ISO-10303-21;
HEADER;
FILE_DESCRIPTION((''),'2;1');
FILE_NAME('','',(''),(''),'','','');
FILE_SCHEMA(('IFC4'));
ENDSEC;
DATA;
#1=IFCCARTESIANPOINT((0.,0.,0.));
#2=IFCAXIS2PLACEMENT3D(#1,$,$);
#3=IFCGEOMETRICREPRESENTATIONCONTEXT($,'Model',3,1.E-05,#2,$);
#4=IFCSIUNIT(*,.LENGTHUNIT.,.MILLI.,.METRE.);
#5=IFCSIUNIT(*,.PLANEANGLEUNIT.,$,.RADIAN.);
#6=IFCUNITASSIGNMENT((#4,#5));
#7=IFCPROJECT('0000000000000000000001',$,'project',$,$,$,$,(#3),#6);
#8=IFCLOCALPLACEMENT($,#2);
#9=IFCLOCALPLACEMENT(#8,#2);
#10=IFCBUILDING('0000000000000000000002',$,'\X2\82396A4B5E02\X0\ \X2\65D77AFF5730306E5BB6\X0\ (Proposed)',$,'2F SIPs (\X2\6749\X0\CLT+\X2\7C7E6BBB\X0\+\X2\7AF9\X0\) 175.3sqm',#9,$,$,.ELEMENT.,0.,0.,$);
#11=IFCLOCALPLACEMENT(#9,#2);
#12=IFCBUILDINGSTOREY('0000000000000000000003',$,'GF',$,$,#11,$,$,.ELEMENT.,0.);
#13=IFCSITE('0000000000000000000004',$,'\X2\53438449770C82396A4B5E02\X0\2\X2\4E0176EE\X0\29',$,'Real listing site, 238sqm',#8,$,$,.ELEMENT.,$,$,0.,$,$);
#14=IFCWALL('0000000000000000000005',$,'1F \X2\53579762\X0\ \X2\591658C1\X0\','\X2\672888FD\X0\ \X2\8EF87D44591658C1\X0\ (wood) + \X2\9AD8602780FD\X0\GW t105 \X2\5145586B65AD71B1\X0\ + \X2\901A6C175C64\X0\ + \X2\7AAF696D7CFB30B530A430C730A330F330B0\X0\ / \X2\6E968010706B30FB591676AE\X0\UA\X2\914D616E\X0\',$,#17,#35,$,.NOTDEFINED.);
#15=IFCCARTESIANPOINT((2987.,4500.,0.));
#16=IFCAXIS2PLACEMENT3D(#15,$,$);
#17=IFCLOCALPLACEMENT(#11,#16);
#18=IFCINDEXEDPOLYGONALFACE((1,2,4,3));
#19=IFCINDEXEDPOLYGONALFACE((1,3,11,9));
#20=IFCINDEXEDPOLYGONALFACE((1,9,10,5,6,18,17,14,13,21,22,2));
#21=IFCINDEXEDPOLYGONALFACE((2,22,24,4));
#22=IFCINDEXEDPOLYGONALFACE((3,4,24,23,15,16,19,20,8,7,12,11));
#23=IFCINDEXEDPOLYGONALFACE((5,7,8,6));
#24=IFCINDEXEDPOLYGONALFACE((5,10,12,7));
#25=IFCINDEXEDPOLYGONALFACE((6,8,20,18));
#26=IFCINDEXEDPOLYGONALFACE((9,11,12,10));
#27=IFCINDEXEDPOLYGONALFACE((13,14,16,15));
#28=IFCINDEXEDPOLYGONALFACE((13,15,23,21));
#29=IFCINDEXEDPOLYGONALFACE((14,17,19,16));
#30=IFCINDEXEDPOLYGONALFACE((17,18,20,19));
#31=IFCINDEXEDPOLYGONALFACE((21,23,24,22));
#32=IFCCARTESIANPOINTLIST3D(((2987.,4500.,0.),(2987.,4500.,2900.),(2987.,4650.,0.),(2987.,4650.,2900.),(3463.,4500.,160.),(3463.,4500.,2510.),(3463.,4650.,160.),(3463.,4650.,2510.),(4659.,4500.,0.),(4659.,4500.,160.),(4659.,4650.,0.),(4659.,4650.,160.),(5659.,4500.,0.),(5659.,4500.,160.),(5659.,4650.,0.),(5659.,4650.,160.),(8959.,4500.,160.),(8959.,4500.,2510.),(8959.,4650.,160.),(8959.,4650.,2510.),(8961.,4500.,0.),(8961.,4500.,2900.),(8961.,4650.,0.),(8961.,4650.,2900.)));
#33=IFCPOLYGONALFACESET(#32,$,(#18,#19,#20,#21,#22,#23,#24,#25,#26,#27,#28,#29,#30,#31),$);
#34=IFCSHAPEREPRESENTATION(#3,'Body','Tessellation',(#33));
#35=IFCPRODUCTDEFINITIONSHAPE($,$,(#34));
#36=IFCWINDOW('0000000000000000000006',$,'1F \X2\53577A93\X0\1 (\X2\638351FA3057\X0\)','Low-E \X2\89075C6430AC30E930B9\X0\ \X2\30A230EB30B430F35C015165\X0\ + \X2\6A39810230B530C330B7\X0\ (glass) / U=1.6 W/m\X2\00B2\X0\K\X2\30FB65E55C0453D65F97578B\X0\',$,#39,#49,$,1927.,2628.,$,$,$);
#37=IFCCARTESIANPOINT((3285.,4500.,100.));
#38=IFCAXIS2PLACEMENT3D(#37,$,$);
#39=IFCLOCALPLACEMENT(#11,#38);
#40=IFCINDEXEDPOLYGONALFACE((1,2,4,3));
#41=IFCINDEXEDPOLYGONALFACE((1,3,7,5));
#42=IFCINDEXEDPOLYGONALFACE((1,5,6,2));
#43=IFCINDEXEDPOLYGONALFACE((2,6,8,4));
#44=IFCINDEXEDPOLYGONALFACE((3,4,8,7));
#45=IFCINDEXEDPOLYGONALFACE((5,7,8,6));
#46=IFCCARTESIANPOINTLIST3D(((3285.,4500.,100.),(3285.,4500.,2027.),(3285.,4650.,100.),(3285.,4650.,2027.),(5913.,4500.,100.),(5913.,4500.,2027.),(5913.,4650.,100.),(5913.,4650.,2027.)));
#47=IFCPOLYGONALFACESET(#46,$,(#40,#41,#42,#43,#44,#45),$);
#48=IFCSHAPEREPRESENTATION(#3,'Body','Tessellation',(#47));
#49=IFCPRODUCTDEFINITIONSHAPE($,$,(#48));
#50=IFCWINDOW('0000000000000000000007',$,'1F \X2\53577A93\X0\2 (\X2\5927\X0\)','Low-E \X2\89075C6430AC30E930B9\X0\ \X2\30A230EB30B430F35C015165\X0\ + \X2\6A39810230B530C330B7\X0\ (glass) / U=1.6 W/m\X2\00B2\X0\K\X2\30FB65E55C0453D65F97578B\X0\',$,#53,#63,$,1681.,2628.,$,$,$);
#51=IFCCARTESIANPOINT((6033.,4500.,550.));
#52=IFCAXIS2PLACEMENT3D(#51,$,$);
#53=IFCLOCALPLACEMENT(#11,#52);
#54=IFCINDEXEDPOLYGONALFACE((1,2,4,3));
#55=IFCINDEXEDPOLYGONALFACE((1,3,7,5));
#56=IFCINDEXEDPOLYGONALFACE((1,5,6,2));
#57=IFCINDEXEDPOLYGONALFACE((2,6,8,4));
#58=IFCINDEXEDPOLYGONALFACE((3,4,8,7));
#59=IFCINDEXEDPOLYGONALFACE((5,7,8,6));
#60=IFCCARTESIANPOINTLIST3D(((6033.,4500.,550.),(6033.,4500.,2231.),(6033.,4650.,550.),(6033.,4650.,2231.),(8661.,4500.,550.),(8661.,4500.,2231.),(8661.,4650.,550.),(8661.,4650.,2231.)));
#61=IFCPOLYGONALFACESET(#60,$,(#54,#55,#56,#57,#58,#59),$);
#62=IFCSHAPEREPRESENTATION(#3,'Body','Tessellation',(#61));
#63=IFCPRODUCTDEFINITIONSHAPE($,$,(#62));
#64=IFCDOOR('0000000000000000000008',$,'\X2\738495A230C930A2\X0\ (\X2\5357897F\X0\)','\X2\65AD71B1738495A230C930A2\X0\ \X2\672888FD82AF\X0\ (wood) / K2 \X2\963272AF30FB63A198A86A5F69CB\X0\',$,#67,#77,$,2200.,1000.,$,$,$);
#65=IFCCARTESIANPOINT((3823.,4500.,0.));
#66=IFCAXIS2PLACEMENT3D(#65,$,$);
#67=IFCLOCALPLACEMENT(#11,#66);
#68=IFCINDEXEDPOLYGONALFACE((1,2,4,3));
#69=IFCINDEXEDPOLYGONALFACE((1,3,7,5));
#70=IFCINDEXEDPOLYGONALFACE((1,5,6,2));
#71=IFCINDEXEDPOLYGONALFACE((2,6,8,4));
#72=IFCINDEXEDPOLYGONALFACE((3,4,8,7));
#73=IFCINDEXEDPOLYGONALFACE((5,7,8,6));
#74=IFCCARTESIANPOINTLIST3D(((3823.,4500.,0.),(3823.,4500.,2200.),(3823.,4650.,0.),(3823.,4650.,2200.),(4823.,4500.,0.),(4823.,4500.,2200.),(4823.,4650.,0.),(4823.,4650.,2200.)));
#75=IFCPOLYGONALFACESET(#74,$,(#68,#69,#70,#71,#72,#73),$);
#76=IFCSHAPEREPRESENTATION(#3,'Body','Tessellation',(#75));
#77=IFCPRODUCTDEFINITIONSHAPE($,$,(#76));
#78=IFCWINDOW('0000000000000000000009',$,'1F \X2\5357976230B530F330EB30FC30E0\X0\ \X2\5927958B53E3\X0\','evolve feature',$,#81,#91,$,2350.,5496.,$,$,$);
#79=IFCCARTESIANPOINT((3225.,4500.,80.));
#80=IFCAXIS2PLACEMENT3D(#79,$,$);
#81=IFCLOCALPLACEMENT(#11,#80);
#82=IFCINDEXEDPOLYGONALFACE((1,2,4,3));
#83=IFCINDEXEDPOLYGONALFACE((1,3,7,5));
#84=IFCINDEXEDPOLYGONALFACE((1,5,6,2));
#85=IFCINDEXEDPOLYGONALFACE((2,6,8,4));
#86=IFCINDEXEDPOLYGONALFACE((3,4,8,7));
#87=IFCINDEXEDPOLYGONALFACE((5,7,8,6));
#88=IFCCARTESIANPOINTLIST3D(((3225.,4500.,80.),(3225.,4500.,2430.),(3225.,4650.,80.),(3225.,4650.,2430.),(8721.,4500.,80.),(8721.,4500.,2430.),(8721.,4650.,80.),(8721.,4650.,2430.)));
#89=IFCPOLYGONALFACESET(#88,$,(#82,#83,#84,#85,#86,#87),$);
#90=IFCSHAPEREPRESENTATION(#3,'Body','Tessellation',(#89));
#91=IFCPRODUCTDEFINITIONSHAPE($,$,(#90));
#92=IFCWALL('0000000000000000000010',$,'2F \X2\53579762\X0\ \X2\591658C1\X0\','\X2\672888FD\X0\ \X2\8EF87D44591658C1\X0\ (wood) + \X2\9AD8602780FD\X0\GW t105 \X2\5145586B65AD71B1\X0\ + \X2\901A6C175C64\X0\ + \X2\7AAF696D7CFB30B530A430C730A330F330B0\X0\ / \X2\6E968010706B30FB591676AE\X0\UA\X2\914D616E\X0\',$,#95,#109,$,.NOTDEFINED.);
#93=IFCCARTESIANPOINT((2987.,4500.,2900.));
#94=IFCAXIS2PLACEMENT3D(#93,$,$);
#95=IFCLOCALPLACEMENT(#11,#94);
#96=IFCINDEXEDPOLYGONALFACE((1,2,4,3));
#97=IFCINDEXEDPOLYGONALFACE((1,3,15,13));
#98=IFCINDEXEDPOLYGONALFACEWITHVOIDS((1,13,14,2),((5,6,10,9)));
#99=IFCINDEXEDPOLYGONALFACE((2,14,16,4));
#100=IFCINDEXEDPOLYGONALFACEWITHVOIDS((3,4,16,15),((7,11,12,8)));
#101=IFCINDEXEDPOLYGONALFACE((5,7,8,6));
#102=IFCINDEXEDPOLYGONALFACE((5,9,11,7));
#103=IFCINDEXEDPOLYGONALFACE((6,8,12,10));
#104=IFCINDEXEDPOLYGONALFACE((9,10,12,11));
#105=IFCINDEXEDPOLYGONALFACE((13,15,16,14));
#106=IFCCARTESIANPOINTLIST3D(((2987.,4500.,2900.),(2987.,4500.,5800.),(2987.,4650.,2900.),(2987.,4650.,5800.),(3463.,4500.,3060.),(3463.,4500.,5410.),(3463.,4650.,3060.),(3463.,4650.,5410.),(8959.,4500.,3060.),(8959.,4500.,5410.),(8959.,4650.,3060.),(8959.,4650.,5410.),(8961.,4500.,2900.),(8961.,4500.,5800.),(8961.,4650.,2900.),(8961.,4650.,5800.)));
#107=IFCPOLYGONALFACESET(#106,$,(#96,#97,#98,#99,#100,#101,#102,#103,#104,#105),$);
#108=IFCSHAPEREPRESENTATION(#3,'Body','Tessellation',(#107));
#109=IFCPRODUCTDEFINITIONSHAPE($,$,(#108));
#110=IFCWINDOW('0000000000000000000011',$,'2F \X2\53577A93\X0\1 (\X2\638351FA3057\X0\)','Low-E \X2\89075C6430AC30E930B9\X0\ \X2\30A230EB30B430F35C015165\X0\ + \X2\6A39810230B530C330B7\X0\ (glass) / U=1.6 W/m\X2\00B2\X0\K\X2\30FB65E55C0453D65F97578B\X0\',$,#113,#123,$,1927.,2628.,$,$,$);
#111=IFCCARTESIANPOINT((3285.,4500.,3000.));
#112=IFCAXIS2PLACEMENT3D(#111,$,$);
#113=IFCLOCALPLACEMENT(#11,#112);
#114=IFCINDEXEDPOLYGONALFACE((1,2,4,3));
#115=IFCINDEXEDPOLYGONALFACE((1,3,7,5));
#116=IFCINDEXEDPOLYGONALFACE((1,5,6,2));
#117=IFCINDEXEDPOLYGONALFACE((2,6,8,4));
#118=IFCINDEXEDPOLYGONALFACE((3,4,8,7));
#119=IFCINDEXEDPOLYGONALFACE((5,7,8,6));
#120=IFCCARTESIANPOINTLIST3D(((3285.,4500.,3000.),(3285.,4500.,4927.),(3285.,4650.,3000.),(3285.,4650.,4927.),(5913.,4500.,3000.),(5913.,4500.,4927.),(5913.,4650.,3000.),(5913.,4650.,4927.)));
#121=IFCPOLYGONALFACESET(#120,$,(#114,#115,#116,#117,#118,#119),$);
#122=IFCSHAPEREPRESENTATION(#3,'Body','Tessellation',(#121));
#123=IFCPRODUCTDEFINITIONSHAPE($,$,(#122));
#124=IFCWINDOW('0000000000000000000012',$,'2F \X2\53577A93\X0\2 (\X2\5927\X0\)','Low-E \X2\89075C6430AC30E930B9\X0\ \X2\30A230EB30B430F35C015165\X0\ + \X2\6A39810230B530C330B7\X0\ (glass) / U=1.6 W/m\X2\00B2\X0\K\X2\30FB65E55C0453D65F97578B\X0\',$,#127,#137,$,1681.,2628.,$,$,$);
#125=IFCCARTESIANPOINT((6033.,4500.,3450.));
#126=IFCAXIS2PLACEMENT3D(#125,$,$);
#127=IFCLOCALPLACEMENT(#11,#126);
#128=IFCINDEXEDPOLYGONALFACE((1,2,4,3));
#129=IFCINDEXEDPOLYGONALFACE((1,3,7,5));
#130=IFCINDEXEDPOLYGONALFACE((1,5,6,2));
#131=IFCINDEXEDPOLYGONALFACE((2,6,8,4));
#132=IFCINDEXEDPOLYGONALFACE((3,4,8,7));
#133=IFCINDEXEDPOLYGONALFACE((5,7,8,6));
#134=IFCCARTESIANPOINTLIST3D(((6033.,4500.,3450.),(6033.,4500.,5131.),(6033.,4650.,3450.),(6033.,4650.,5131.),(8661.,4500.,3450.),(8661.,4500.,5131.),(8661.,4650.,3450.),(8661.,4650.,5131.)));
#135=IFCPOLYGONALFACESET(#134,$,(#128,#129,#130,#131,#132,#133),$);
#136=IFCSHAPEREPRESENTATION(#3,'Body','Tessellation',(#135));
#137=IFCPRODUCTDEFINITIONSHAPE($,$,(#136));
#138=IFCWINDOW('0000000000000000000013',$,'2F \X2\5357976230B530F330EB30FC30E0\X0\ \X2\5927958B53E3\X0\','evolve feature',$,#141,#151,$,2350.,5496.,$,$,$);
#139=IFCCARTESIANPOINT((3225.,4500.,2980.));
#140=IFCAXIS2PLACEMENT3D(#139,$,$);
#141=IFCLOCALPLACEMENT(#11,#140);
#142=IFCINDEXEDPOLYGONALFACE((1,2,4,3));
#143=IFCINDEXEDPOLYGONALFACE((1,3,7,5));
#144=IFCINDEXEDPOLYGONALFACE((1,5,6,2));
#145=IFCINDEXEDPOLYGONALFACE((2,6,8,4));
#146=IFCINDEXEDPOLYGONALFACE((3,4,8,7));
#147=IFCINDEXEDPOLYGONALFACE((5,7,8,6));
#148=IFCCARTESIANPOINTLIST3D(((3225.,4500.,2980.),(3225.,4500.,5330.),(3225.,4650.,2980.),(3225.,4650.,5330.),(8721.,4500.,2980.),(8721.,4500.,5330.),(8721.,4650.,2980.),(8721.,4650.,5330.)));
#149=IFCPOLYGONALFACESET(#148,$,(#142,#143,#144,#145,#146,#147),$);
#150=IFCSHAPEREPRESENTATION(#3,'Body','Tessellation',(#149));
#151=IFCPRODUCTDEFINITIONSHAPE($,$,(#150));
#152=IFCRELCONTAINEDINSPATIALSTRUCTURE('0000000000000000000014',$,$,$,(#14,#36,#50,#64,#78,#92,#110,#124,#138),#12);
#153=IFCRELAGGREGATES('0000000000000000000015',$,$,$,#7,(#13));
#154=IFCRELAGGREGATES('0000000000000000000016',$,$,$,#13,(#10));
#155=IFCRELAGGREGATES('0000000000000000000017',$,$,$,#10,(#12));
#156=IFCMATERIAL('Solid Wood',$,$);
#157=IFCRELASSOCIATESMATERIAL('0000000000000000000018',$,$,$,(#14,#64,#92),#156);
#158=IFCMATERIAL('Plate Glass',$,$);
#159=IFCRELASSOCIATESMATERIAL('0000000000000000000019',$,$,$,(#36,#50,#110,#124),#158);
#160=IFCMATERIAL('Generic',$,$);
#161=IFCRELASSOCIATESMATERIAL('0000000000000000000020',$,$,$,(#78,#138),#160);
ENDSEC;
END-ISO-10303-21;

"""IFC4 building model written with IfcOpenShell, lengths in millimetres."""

from ifc_helpers import new_model, si_unit, frame, frame_2d, origin, place, context, project, spatial, rectangle, extrude, material, element, fill, save


model = new_model("IFC4")

# Units and contexts
model_context = context("Model", 3, precision=1e-05, world=origin())
ifc_project = project(units=[si_unit("LENGTHUNIT", "METRE", prefix="MILLI"), si_unit("PLANEANGLEUNIT", "RADIAN")], contexts=[model_context])

# Site, building, storey
site_placement = place(None, origin())
site = spatial("IfcSite", under=ifc_project, at=site_placement, Name="千葉県船橋市2丁目29", ObjectType="Real listing site, 238sqm", CompositionType="ELEMENT", RefElevation=0.0)
building_placement = place(site_placement, origin())
building = spatial("IfcBuilding", under=site, at=building_placement, Name="船橋市 旗竿地の家 (Proposed)", ObjectType="2F SIPs (杉CLT+籾殻+竹) 175.3sqm", CompositionType="ELEMENT", ElevationOfRefHeight=0.0, ElevationOfTerrain=0.0)
storey_placement = place(building_placement, origin())
storey = spatial("IfcBuildingStorey", under=building, at=storey_placement, Name="GF", CompositionType="ELEMENT", Elevation=0.0)

# Shared definitions
ifc_material_1 = material(Name="Solid Wood")
ifc_material_2 = material(Name="Generic")

# Wall, openings, windows, door
wall_1_placement = place(storey_placement, frame((2987.0, 4500.0, 0.0)))
wall_1 = element("IfcWall", 1, at=wall_1_placement, inside=storey, material=ifc_material_1, Name="1F 南面 外壁", Description="木製 軸組外壁 (wood) + 高性能GW t105 充填断熱 + 通気層 + 窯業系サイディング / 準耐火・外皮UA配慮", PredefinedType="NOTDEFINED", context=model_context, shape_type="SweptSolid", body=[
    extrude(rectangle(XDim=5974.0, YDim=150.0, at=frame_2d((2987.0, 75.0))), frame((2987.0, 4500.0, 0.0)), (0.0, 0.0, 1.0), 2900.0),
])
opening_1_placement = place(storey_placement, frame((3285.0, 4500.0, 100.0)))
opening_1 = element("IfcOpeningElement", 2, at=opening_1_placement, cuts=wall_1, PredefinedType="NOTDEFINED", context=model_context, shape_type="SweptSolid", body=[
    extrude(rectangle(XDim=2628.0, YDim=150.0, at=frame_2d((1314.0, 75.0))), frame((3285.0, 4500.0, 100.0)), (0.0, 0.0, 1.0), 1927.0),
])
opening_2_placement = place(storey_placement, frame((6033.0, 4500.0, 550.0)))
opening_2 = element("IfcOpeningElement", 3, at=opening_2_placement, cuts=wall_1, PredefinedType="NOTDEFINED", context=model_context, shape_type="SweptSolid", body=[
    extrude(rectangle(XDim=2628.0, YDim=150.0, at=frame_2d((1314.0, 75.0))), frame((6033.0, 4500.0, 550.0)), (0.0, 0.0, 1.0), 1681.0),
])
opening_3_placement = place(storey_placement, frame((3823.0, 4500.0, 0.0)))
opening_3 = element("IfcOpeningElement", 4, at=opening_3_placement, cuts=wall_1, PredefinedType="NOTDEFINED", context=model_context, shape_type="SweptSolid", body=[
    extrude(rectangle(XDim=1000.0, YDim=150.0, at=frame_2d((500.0, 75.0))), frame((3823.0, 4500.0, 0.0)), (0.0, 0.0, 1.0), 2200.0),
])
opening_4_placement = place(storey_placement, frame((3225.0, 4500.0, 80.0)))
opening_4 = element("IfcOpeningElement", 5, at=opening_4_placement, cuts=wall_1, PredefinedType="NOTDEFINED", context=model_context, shape_type="SweptSolid", body=[
    extrude(rectangle(XDim=5496.0, YDim=150.0, at=frame_2d((2748.0, 75.0))), frame((3225.0, 4500.0, 80.0)), (0.0, 0.0, 1.0), 2350.0),
])
ifc_material_3 = material(Name="Plate Glass")
window_1_placement = place(storey_placement, frame((3285.0, 4500.0, 100.0)))
window_1 = element("IfcWindow", 6, at=window_1_placement, inside=storey, material=ifc_material_3, Name="1F 南窓1 (掃出し)", Description="Low-E 複層ガラス アルゴン封入 + 樹脂サッシ (glass) / U=1.6 W/m²K・日射取得型", OverallHeight=1927.0, OverallWidth=2628.0, context=model_context, shape_type="SweptSolid", body=[
    extrude(rectangle(XDim=2628.0, YDim=150.0, at=frame_2d((1314.0, 75.0))), frame((3285.0, 4500.0, 100.0)), (0.0, 0.0, 1.0), 1927.0),
])
fill(opening_1, window_1)
window_2_placement = place(storey_placement, frame((6033.0, 4500.0, 550.0)))
window_2 = element("IfcWindow", 7, at=window_2_placement, inside=storey, material=ifc_material_3, Name="1F 南窓2 (大)", Description="Low-E 複層ガラス アルゴン封入 + 樹脂サッシ (glass) / U=1.6 W/m²K・日射取得型", OverallHeight=1681.0, OverallWidth=2628.0, context=model_context, shape_type="SweptSolid", body=[
    extrude(rectangle(XDim=2628.0, YDim=150.0, at=frame_2d((1314.0, 75.0))), frame((6033.0, 4500.0, 550.0)), (0.0, 0.0, 1.0), 1681.0),
])
fill(opening_2, window_2)
door_placement = place(storey_placement, frame((3823.0, 4500.0, 0.0)))
door = element("IfcDoor", 8, at=door_placement, inside=storey, material=ifc_material_1, Name="玄関ドア (南西)", Description="断熱玄関ドア 木製芯 (wood) / K2 防犯・採風機構", OverallHeight=2200.0, OverallWidth=1000.0, context=model_context, shape_type="SweptSolid", body=[
    extrude(rectangle(XDim=1000.0, YDim=150.0, at=frame_2d((500.0, 75.0))), frame((3823.0, 4500.0, 0.0)), (0.0, 0.0, 1.0), 2200.0),
])
fill(opening_3, door)
window_3_placement = place(storey_placement, frame((3225.0, 4500.0, 80.0)))
window_3 = element("IfcWindow", 9, at=window_3_placement, inside=storey, material=ifc_material_2, Name="1F 南面サンルーム 大開口", Description="evolve feature", OverallHeight=2350.0, OverallWidth=5496.0, context=model_context, shape_type="SweptSolid", body=[
    extrude(rectangle(XDim=5496.0, YDim=150.0, at=frame_2d((2748.0, 75.0))), frame((3225.0, 4500.0, 80.0)), (0.0, 0.0, 1.0), 2350.0),
])
fill(opening_4, window_3)

# Wall, openings, windows
wall_2_placement = place(storey_placement, frame((2987.0, 4500.0, 2900.0)))
wall_2 = element("IfcWall", 10, at=wall_2_placement, inside=storey, material=ifc_material_1, Name="2F 南面 外壁", Description="木製 軸組外壁 (wood) + 高性能GW t105 充填断熱 + 通気層 + 窯業系サイディング / 準耐火・外皮UA配慮", PredefinedType="NOTDEFINED", context=model_context, shape_type="SweptSolid", body=[
    extrude(rectangle(XDim=5974.0, YDim=150.0, at=frame_2d((2987.0, 75.0))), frame((2987.0, 4500.0, 2900.0)), (0.0, 0.0, 1.0), 2900.0),
])
opening_5_placement = place(storey_placement, frame((3285.0, 4500.0, 3000.0)))
opening_5 = element("IfcOpeningElement", 11, at=opening_5_placement, cuts=wall_2, PredefinedType="NOTDEFINED", context=model_context, shape_type="SweptSolid", body=[
    extrude(rectangle(XDim=2628.0, YDim=150.0, at=frame_2d((1314.0, 75.0))), frame((3285.0, 4500.0, 3000.0)), (0.0, 0.0, 1.0), 1927.0),
])
opening_6_placement = place(storey_placement, frame((6033.0, 4500.0, 3450.0)))
opening_6 = element("IfcOpeningElement", 12, at=opening_6_placement, cuts=wall_2, PredefinedType="NOTDEFINED", context=model_context, shape_type="SweptSolid", body=[
    extrude(rectangle(XDim=2628.0, YDim=150.0, at=frame_2d((1314.0, 75.0))), frame((6033.0, 4500.0, 3450.0)), (0.0, 0.0, 1.0), 1681.0),
])
opening_7_placement = place(storey_placement, frame((3225.0, 4500.0, 2980.0)))
opening_7 = element("IfcOpeningElement", 13, at=opening_7_placement, cuts=wall_2, PredefinedType="NOTDEFINED", context=model_context, shape_type="SweptSolid", body=[
    extrude(rectangle(XDim=5496.0, YDim=150.0, at=frame_2d((2748.0, 75.0))), frame((3225.0, 4500.0, 2980.0)), (0.0, 0.0, 1.0), 2350.0),
])
window_4_placement = place(storey_placement, frame((3285.0, 4500.0, 3000.0)))
window_4 = element("IfcWindow", 14, at=window_4_placement, inside=storey, material=ifc_material_3, Name="2F 南窓1 (掃出し)", Description="Low-E 複層ガラス アルゴン封入 + 樹脂サッシ (glass) / U=1.6 W/m²K・日射取得型", OverallHeight=1927.0, OverallWidth=2628.0, context=model_context, shape_type="SweptSolid", body=[
    extrude(rectangle(XDim=2628.0, YDim=150.0, at=frame_2d((1314.0, 75.0))), frame((3285.0, 4500.0, 3000.0)), (0.0, 0.0, 1.0), 1927.0),
])
fill(opening_5, window_4)
window_5_placement = place(storey_placement, frame((6033.0, 4500.0, 3450.0)))
window_5 = element("IfcWindow", 15, at=window_5_placement, inside=storey, material=ifc_material_3, Name="2F 南窓2 (大)", Description="Low-E 複層ガラス アルゴン封入 + 樹脂サッシ (glass) / U=1.6 W/m²K・日射取得型", OverallHeight=1681.0, OverallWidth=2628.0, context=model_context, shape_type="SweptSolid", body=[
    extrude(rectangle(XDim=2628.0, YDim=150.0, at=frame_2d((1314.0, 75.0))), frame((6033.0, 4500.0, 3450.0)), (0.0, 0.0, 1.0), 1681.0),
])
fill(opening_6, window_5)
window_6_placement = place(storey_placement, frame((3225.0, 4500.0, 2980.0)))
window_6 = element("IfcWindow", 16, at=window_6_placement, inside=storey, material=ifc_material_2, Name="2F 南面サンルーム 大開口", Description="evolve feature", OverallHeight=2350.0, OverallWidth=5496.0, context=model_context, shape_type="SweptSolid", body=[
    extrude(rectangle(XDim=5496.0, YDim=150.0, at=frame_2d((2748.0, 75.0))), frame((3225.0, 4500.0, 2980.0)), (0.0, 0.0, 1.0), 2350.0),
])
fill(opening_7, window_6)

save(model, "model.ifc")
